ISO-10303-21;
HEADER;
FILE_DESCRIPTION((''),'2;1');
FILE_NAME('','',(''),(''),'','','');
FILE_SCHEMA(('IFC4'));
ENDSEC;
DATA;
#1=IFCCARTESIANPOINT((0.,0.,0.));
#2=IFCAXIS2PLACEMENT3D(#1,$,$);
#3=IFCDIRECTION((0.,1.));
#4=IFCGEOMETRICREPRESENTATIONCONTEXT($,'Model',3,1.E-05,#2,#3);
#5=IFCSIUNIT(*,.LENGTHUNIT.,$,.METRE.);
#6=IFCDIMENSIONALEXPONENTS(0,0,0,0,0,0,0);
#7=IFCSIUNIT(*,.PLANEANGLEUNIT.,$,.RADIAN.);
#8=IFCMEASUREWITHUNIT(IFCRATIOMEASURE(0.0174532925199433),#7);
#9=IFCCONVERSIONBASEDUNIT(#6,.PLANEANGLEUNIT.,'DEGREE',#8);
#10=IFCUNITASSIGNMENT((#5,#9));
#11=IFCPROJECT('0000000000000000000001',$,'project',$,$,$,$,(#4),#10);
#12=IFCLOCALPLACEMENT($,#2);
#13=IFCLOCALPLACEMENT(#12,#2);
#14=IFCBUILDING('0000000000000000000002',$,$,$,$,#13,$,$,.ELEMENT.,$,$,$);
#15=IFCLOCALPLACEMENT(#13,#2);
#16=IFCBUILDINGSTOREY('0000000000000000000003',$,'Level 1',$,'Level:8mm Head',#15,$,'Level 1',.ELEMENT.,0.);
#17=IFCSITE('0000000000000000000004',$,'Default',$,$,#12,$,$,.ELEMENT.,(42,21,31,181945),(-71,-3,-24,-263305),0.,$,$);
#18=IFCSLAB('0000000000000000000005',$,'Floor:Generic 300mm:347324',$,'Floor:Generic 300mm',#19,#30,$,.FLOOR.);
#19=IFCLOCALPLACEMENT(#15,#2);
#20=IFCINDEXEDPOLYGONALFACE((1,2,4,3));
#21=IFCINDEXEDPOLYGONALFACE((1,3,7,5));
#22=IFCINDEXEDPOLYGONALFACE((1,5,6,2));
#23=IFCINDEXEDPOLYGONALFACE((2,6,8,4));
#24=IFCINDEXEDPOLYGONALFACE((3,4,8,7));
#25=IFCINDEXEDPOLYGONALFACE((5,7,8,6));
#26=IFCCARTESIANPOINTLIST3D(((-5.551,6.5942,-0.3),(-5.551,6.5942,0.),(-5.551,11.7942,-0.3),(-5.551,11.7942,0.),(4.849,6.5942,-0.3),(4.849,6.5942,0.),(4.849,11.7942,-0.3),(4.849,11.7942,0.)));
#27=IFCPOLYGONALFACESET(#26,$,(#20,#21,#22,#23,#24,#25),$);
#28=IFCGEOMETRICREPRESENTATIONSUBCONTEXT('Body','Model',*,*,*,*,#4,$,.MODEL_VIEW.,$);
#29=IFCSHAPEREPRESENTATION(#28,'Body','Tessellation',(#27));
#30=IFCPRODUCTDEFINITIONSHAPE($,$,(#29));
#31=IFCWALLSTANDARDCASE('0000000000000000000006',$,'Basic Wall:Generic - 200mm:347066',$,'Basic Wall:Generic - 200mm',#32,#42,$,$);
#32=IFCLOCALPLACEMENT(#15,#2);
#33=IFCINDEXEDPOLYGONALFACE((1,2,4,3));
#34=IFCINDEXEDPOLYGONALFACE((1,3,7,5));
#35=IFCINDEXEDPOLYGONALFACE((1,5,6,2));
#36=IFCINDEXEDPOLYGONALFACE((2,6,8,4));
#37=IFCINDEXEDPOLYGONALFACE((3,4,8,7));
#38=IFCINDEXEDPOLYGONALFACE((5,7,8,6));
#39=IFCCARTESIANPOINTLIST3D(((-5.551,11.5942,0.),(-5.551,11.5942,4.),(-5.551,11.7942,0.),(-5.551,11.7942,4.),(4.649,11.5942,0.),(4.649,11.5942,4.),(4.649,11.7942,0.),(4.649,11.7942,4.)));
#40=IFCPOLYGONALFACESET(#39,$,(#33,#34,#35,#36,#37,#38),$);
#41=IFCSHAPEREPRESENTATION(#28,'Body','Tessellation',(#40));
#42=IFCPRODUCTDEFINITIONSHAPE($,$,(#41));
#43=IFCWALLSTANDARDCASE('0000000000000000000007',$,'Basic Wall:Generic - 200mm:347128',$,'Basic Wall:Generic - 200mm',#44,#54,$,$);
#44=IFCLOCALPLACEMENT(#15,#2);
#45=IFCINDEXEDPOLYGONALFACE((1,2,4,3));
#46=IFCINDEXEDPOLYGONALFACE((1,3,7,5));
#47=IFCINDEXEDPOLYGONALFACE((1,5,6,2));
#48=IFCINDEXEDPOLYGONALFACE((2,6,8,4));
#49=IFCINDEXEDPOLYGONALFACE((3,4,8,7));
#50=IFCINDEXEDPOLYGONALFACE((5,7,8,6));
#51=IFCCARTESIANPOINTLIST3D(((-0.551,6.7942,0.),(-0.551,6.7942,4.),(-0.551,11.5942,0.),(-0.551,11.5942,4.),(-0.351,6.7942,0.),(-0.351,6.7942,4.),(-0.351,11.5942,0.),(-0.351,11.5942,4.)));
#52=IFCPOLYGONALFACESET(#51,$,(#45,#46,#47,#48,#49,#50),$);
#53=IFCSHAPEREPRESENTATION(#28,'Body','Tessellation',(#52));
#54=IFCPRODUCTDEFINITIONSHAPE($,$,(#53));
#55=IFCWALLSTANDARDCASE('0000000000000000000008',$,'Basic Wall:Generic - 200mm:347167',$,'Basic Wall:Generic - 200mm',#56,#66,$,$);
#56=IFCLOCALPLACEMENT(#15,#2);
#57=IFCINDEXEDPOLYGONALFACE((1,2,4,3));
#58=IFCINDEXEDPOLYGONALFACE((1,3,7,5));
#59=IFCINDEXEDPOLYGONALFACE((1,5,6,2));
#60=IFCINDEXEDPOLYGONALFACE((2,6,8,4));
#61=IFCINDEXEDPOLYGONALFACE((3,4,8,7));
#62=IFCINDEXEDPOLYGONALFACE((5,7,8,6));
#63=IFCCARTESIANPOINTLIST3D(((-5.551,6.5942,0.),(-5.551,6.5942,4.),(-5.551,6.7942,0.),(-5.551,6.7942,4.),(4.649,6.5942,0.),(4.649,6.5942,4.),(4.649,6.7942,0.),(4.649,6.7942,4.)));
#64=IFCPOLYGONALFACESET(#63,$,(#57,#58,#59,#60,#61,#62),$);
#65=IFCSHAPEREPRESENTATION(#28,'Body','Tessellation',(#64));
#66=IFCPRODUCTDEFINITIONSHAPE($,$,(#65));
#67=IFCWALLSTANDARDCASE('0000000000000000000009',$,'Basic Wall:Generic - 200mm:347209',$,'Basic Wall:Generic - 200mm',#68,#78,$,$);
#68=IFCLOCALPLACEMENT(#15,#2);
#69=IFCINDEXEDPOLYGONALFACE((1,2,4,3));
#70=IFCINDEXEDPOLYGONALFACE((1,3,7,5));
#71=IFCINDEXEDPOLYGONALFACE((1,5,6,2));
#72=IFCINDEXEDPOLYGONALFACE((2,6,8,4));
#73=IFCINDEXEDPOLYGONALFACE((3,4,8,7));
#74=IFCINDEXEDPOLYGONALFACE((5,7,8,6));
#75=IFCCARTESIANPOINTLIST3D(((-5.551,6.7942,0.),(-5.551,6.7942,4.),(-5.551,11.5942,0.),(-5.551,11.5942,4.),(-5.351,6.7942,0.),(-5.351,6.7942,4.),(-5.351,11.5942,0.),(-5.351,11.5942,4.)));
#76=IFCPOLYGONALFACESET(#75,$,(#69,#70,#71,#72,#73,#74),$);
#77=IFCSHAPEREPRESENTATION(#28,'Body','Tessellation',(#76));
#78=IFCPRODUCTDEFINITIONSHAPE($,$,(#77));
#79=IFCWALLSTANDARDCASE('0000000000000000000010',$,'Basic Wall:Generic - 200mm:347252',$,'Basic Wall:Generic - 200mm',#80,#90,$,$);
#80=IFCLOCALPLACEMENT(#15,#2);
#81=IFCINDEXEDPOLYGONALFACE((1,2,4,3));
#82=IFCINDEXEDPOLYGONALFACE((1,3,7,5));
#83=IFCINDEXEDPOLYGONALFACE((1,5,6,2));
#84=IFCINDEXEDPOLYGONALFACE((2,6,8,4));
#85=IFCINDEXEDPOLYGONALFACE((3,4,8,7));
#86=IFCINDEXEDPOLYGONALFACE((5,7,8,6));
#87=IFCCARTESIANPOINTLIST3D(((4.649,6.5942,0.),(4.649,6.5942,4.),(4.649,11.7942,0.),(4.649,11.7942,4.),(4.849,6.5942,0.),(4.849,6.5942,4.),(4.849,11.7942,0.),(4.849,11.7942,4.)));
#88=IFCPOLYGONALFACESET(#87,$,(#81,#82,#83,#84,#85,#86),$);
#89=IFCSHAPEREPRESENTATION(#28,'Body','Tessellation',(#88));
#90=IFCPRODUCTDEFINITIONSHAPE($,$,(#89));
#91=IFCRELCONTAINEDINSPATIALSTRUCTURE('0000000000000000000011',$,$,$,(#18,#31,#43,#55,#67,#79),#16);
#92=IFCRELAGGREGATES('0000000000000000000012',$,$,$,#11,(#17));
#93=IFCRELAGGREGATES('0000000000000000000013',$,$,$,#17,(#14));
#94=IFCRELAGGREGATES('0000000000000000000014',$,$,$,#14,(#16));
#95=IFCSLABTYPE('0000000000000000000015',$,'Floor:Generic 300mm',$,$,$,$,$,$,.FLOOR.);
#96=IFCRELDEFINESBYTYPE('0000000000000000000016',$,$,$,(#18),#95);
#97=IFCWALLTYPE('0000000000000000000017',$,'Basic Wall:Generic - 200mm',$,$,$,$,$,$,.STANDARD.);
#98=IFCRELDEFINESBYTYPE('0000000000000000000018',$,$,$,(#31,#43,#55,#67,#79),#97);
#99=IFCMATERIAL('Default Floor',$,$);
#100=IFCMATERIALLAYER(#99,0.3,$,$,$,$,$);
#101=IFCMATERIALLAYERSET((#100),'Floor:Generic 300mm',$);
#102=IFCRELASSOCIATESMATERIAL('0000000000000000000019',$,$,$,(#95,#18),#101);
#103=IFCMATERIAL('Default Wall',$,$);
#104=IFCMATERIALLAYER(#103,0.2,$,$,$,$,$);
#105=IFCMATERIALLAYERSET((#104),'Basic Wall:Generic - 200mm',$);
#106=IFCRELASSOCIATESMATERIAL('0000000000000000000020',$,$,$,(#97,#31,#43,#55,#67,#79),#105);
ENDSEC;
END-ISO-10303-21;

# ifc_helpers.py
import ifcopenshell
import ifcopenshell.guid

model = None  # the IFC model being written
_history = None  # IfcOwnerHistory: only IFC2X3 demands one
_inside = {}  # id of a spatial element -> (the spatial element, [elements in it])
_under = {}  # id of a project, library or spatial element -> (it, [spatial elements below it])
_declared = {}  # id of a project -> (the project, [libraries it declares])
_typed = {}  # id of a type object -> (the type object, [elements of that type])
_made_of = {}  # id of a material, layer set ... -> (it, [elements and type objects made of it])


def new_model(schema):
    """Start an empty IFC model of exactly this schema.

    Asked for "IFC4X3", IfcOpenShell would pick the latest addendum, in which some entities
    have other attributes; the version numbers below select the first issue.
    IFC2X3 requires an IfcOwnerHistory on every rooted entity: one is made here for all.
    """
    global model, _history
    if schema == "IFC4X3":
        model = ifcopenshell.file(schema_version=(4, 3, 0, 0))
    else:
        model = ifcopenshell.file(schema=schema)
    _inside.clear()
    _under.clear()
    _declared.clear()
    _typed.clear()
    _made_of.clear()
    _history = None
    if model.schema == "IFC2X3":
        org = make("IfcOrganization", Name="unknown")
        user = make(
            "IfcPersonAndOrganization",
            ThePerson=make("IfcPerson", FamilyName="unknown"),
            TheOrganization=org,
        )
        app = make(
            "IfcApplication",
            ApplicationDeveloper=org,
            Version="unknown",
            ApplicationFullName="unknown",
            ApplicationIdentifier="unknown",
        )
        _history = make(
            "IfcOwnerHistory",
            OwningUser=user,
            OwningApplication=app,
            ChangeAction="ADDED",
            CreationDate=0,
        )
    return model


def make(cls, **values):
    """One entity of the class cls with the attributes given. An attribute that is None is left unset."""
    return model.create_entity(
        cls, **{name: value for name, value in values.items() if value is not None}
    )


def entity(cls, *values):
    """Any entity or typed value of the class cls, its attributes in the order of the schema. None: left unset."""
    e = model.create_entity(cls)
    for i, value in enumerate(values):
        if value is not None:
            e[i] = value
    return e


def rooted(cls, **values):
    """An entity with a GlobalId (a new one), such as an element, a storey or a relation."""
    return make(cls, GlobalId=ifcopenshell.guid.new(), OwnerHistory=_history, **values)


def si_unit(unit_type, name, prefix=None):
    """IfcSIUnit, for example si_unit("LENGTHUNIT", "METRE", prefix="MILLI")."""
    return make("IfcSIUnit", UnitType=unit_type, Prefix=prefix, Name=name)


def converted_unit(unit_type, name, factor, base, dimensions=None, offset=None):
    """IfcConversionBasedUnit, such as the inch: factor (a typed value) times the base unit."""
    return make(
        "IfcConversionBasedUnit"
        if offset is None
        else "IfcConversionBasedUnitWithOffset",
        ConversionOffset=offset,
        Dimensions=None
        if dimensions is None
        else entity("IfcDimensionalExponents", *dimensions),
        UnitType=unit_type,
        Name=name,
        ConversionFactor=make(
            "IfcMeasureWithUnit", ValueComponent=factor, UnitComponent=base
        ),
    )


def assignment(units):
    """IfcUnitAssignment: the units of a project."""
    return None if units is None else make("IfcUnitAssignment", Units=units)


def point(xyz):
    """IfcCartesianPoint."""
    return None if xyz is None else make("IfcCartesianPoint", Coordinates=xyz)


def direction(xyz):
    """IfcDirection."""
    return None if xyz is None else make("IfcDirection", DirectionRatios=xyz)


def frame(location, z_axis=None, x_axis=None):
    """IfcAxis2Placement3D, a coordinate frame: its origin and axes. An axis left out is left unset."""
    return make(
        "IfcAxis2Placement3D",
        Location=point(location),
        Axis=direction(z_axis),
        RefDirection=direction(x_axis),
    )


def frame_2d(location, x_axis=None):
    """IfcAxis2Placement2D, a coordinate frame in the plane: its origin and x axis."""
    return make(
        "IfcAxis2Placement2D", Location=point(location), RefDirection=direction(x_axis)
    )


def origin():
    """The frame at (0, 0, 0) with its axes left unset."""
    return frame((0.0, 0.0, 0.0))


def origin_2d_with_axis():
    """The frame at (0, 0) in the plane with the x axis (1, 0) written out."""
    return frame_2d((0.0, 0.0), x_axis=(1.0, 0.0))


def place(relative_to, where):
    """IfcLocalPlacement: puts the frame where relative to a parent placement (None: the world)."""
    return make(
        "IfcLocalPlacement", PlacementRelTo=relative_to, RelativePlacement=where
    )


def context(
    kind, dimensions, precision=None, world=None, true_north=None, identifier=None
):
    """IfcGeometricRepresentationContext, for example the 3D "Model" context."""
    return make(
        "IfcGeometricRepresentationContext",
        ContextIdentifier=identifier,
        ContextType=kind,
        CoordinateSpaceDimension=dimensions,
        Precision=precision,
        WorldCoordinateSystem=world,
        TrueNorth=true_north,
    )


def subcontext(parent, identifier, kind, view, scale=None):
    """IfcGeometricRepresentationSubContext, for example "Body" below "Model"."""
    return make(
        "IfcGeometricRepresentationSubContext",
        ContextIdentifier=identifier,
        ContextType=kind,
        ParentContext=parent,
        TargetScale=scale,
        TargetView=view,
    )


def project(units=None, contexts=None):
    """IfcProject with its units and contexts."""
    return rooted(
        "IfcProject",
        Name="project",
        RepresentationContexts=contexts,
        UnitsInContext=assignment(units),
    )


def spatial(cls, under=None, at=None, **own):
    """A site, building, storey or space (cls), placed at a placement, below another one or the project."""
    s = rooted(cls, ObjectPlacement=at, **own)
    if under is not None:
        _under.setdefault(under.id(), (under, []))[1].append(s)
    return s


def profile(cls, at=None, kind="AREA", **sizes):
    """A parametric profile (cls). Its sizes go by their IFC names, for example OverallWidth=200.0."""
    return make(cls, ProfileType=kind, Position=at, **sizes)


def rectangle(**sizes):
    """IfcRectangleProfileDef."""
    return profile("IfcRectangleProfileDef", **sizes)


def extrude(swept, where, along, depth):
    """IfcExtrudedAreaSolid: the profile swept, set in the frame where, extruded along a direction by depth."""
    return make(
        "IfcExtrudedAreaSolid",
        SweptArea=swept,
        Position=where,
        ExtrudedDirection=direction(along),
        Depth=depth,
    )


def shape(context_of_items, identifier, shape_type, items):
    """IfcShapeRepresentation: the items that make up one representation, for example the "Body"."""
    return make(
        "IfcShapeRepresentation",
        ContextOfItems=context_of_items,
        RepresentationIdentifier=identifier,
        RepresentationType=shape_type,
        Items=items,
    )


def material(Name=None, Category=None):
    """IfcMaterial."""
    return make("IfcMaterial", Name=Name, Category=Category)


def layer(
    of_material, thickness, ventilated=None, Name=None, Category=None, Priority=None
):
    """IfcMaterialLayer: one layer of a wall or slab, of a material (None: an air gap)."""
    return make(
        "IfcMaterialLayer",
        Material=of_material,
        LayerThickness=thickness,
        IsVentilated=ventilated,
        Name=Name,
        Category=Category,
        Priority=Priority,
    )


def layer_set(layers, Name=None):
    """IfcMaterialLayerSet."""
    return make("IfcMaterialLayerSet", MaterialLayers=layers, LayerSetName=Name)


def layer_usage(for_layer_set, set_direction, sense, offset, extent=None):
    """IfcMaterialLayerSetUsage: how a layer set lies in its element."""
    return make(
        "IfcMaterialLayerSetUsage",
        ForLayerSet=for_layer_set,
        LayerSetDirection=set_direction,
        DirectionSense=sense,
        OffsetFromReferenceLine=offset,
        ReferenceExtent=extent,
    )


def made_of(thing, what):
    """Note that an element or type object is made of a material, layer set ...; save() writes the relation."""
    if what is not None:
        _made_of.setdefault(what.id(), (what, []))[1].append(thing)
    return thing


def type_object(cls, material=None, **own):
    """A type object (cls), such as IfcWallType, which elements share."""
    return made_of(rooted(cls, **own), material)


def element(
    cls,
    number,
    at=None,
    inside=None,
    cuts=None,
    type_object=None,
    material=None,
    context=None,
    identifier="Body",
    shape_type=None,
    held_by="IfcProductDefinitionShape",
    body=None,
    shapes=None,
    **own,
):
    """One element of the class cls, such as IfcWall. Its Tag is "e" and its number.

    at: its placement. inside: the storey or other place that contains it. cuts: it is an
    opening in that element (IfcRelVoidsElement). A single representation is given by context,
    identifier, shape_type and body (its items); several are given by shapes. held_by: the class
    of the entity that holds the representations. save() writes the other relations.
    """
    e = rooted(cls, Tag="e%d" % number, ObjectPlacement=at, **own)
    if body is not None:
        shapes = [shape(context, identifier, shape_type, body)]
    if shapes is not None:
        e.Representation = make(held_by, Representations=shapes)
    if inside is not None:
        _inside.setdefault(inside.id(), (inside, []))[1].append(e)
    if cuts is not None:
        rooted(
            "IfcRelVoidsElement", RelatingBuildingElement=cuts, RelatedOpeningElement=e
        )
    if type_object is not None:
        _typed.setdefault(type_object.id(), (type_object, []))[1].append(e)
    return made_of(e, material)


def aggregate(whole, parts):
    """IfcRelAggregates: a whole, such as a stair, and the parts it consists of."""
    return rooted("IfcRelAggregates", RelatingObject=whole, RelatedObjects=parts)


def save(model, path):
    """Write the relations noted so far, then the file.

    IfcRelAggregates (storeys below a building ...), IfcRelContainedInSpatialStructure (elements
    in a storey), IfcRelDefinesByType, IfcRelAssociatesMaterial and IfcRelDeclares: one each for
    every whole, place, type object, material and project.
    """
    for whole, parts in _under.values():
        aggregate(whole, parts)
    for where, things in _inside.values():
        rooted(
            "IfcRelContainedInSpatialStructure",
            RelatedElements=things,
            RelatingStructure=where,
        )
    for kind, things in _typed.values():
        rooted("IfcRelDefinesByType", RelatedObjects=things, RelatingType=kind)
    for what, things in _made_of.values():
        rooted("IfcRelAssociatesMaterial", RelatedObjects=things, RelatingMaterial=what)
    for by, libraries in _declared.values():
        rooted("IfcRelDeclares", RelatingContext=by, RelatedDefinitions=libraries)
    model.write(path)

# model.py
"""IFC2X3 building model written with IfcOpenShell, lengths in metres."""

from ifc_helpers import new_model, entity, si_unit, converted_unit, direction, frame, frame_2d, origin, origin_2d_with_axis, place, context, subcontext, project, spatial, rectangle, extrude, material, layer, layer_set, layer_usage, type_object, element, save


model = new_model("IFC2X3")

# Units and contexts
model_context = context("Model", 3, precision=1e-05, world=origin(), true_north=direction((0.0, 1.0)))
body_context = subcontext(model_context, "Body", "Model", "MODEL_VIEW")
ifc_project = project(units=[si_unit("LENGTHUNIT", "METRE"), converted_unit("PLANEANGLEUNIT", "DEGREE", entity("IfcRatioMeasure", 0.0174532925199433), si_unit("PLANEANGLEUNIT", "RADIAN"), dimensions=[0, 0, 0, 0, 0, 0, 0])], contexts=[model_context])

# Site, building, storey
site_placement = place(None, origin())
site = spatial("IfcSite", under=ifc_project, at=site_placement, Name="Default", CompositionType="ELEMENT", RefLatitude=(42, 21, 31, 181945), RefLongitude=(-71, -3, -24, -263305), RefElevation=0.0)
building_placement = place(site_placement, origin())
building = spatial("IfcBuilding", under=site, at=building_placement, CompositionType="ELEMENT")
storey_placement = place(building_placement, origin())
storey = spatial("IfcBuildingStorey", under=building, at=storey_placement, Name="Level 1", ObjectType="Level:8mm Head", LongName="Level 1", CompositionType="ELEMENT", Elevation=0.0)

# Slab
ifc_material_1 = material(Name="Default Floor")
ifc_layer_1 = layer(ifc_material_1, 0.3)
ifc_layer_set_1 = layer_set([ifc_layer_1], Name="Floor:Generic 300mm")
ifc_layer_usage_1 = layer_usage(ifc_layer_set_1, "AXIS3", "POSITIVE", 0.0)
slab_type = type_object("IfcSlabType", Name="Floor:Generic 300mm", PredefinedType="FLOOR", material=ifc_layer_set_1)
slab_placement = place(storey_placement, origin())
element("IfcSlab", 1, at=slab_placement, inside=storey, type_object=slab_type, material=ifc_layer_usage_1, Name="Floor:Generic 300mm:347324", ObjectType="Floor:Generic 300mm", PredefinedType="FLOOR", context=body_context, shape_type="SweptSolid", body=[
    extrude(rectangle(XDim=5.2, YDim=10.4, at=origin_2d_with_axis()), frame((-0.351, 9.1942, 0.0), z_axis=(0.0, 0.0, -1.0), x_axis=(0.0, 1.0, 0.0)), (0.0, 0.0, 1.0), 0.3),
])

# Walls
ifc_material_2 = material(Name="Default Wall")
ifc_layer_2 = layer(ifc_material_2, 0.2)
ifc_layer_set_2 = layer_set([ifc_layer_2], Name="Basic Wall:Generic - 200mm")
ifc_layer_usage_2 = layer_usage(ifc_layer_set_2, "AXIS2", "NEGATIVE", 0.1)
wall_type = type_object("IfcWallType", Name="Basic Wall:Generic - 200mm", PredefinedType="STANDARD", material=ifc_layer_set_2)
wall_1_placement = place(storey_placement, frame((-5.551, 11.6942, 0.0)))
element("IfcWallStandardCase", 2, at=wall_1_placement, inside=storey, type_object=wall_type, material=ifc_layer_usage_2, Name="Basic Wall:Generic - 200mm:347066", ObjectType="Basic Wall:Generic - 200mm", context=body_context, shape_type="SweptSolid", body=[
    extrude(rectangle(XDim=10.2, YDim=0.2, at=frame_2d((5.1, 0.0), x_axis=(-1.0, 0.0))), origin(), (0.0, 0.0, 1.0), 4.0),
])
ifc_layer_usage_3 = layer_usage(ifc_layer_set_2, "AXIS2", "NEGATIVE", 0.1)
wall_2_placement = place(storey_placement, frame((-0.451, 11.5942, 0.0), z_axis=(0.0, 0.0, 1.0), x_axis=(0.0, -1.0, 0.0)))
element("IfcWallStandardCase", 3, at=wall_2_placement, inside=storey, type_object=wall_type, material=ifc_layer_usage_3, Name="Basic Wall:Generic - 200mm:347128", ObjectType="Basic Wall:Generic - 200mm", context=body_context, shape_type="SweptSolid", body=[
    extrude(rectangle(XDim=4.8, YDim=0.2, at=frame_2d((2.4, 0.0), x_axis=(-1.0, 0.0))), origin(), (0.0, 0.0, 1.0), 4.0),
])
ifc_layer_usage_4 = layer_usage(ifc_layer_set_2, "AXIS2", "NEGATIVE", 0.1)
wall_3_placement = place(storey_placement, frame((4.649, 6.6942, 0.0), z_axis=(0.0, 0.0, 1.0), x_axis=(-1.0, 0.0, 0.0)))
element("IfcWallStandardCase", 4, at=wall_3_placement, inside=storey, type_object=wall_type, material=ifc_layer_usage_4, Name="Basic Wall:Generic - 200mm:347167", ObjectType="Basic Wall:Generic - 200mm", context=body_context, shape_type="SweptSolid", body=[
    extrude(rectangle(XDim=10.2, YDim=0.2, at=frame_2d((5.1, 0.0), x_axis=(-1.0, 0.0))), origin(), (0.0, 0.0, 1.0), 4.0),
])
ifc_layer_usage_5 = layer_usage(ifc_layer_set_2, "AXIS2", "NEGATIVE", 0.1)
wall_4_placement = place(storey_placement, frame((-5.451, 6.7942, 0.0), z_axis=(0.0, 0.0, 1.0), x_axis=(0.0, 1.0, 0.0)))
element("IfcWallStandardCase", 5, at=wall_4_placement, inside=storey, type_object=wall_type, material=ifc_layer_usage_5, Name="Basic Wall:Generic - 200mm:347209", ObjectType="Basic Wall:Generic - 200mm", context=body_context, shape_type="SweptSolid", body=[
    extrude(rectangle(XDim=4.8, YDim=0.2, at=frame_2d((2.4, 0.0), x_axis=(-1.0, 0.0))), origin(), (0.0, 0.0, 1.0), 4.0),
])
ifc_layer_usage_6 = layer_usage(ifc_layer_set_2, "AXIS2", "NEGATIVE", 0.1)
wall_5_placement = place(storey_placement, frame((4.749, 11.7942, 0.0), z_axis=(0.0, 0.0, 1.0), x_axis=(0.0, -1.0, 0.0)))
element("IfcWallStandardCase", 6, at=wall_5_placement, inside=storey, type_object=wall_type, material=ifc_layer_usage_6, Name="Basic Wall:Generic - 200mm:347252", ObjectType="Basic Wall:Generic - 200mm", context=body_context, shape_type="SweptSolid", body=[
    extrude(rectangle(XDim=5.2, YDim=0.2, at=frame_2d((2.6, 0.0), x_axis=(-1.0, 0.0))), origin(), (0.0, 0.0, 1.0), 4.0),
])

save(model, "model.ifc")
